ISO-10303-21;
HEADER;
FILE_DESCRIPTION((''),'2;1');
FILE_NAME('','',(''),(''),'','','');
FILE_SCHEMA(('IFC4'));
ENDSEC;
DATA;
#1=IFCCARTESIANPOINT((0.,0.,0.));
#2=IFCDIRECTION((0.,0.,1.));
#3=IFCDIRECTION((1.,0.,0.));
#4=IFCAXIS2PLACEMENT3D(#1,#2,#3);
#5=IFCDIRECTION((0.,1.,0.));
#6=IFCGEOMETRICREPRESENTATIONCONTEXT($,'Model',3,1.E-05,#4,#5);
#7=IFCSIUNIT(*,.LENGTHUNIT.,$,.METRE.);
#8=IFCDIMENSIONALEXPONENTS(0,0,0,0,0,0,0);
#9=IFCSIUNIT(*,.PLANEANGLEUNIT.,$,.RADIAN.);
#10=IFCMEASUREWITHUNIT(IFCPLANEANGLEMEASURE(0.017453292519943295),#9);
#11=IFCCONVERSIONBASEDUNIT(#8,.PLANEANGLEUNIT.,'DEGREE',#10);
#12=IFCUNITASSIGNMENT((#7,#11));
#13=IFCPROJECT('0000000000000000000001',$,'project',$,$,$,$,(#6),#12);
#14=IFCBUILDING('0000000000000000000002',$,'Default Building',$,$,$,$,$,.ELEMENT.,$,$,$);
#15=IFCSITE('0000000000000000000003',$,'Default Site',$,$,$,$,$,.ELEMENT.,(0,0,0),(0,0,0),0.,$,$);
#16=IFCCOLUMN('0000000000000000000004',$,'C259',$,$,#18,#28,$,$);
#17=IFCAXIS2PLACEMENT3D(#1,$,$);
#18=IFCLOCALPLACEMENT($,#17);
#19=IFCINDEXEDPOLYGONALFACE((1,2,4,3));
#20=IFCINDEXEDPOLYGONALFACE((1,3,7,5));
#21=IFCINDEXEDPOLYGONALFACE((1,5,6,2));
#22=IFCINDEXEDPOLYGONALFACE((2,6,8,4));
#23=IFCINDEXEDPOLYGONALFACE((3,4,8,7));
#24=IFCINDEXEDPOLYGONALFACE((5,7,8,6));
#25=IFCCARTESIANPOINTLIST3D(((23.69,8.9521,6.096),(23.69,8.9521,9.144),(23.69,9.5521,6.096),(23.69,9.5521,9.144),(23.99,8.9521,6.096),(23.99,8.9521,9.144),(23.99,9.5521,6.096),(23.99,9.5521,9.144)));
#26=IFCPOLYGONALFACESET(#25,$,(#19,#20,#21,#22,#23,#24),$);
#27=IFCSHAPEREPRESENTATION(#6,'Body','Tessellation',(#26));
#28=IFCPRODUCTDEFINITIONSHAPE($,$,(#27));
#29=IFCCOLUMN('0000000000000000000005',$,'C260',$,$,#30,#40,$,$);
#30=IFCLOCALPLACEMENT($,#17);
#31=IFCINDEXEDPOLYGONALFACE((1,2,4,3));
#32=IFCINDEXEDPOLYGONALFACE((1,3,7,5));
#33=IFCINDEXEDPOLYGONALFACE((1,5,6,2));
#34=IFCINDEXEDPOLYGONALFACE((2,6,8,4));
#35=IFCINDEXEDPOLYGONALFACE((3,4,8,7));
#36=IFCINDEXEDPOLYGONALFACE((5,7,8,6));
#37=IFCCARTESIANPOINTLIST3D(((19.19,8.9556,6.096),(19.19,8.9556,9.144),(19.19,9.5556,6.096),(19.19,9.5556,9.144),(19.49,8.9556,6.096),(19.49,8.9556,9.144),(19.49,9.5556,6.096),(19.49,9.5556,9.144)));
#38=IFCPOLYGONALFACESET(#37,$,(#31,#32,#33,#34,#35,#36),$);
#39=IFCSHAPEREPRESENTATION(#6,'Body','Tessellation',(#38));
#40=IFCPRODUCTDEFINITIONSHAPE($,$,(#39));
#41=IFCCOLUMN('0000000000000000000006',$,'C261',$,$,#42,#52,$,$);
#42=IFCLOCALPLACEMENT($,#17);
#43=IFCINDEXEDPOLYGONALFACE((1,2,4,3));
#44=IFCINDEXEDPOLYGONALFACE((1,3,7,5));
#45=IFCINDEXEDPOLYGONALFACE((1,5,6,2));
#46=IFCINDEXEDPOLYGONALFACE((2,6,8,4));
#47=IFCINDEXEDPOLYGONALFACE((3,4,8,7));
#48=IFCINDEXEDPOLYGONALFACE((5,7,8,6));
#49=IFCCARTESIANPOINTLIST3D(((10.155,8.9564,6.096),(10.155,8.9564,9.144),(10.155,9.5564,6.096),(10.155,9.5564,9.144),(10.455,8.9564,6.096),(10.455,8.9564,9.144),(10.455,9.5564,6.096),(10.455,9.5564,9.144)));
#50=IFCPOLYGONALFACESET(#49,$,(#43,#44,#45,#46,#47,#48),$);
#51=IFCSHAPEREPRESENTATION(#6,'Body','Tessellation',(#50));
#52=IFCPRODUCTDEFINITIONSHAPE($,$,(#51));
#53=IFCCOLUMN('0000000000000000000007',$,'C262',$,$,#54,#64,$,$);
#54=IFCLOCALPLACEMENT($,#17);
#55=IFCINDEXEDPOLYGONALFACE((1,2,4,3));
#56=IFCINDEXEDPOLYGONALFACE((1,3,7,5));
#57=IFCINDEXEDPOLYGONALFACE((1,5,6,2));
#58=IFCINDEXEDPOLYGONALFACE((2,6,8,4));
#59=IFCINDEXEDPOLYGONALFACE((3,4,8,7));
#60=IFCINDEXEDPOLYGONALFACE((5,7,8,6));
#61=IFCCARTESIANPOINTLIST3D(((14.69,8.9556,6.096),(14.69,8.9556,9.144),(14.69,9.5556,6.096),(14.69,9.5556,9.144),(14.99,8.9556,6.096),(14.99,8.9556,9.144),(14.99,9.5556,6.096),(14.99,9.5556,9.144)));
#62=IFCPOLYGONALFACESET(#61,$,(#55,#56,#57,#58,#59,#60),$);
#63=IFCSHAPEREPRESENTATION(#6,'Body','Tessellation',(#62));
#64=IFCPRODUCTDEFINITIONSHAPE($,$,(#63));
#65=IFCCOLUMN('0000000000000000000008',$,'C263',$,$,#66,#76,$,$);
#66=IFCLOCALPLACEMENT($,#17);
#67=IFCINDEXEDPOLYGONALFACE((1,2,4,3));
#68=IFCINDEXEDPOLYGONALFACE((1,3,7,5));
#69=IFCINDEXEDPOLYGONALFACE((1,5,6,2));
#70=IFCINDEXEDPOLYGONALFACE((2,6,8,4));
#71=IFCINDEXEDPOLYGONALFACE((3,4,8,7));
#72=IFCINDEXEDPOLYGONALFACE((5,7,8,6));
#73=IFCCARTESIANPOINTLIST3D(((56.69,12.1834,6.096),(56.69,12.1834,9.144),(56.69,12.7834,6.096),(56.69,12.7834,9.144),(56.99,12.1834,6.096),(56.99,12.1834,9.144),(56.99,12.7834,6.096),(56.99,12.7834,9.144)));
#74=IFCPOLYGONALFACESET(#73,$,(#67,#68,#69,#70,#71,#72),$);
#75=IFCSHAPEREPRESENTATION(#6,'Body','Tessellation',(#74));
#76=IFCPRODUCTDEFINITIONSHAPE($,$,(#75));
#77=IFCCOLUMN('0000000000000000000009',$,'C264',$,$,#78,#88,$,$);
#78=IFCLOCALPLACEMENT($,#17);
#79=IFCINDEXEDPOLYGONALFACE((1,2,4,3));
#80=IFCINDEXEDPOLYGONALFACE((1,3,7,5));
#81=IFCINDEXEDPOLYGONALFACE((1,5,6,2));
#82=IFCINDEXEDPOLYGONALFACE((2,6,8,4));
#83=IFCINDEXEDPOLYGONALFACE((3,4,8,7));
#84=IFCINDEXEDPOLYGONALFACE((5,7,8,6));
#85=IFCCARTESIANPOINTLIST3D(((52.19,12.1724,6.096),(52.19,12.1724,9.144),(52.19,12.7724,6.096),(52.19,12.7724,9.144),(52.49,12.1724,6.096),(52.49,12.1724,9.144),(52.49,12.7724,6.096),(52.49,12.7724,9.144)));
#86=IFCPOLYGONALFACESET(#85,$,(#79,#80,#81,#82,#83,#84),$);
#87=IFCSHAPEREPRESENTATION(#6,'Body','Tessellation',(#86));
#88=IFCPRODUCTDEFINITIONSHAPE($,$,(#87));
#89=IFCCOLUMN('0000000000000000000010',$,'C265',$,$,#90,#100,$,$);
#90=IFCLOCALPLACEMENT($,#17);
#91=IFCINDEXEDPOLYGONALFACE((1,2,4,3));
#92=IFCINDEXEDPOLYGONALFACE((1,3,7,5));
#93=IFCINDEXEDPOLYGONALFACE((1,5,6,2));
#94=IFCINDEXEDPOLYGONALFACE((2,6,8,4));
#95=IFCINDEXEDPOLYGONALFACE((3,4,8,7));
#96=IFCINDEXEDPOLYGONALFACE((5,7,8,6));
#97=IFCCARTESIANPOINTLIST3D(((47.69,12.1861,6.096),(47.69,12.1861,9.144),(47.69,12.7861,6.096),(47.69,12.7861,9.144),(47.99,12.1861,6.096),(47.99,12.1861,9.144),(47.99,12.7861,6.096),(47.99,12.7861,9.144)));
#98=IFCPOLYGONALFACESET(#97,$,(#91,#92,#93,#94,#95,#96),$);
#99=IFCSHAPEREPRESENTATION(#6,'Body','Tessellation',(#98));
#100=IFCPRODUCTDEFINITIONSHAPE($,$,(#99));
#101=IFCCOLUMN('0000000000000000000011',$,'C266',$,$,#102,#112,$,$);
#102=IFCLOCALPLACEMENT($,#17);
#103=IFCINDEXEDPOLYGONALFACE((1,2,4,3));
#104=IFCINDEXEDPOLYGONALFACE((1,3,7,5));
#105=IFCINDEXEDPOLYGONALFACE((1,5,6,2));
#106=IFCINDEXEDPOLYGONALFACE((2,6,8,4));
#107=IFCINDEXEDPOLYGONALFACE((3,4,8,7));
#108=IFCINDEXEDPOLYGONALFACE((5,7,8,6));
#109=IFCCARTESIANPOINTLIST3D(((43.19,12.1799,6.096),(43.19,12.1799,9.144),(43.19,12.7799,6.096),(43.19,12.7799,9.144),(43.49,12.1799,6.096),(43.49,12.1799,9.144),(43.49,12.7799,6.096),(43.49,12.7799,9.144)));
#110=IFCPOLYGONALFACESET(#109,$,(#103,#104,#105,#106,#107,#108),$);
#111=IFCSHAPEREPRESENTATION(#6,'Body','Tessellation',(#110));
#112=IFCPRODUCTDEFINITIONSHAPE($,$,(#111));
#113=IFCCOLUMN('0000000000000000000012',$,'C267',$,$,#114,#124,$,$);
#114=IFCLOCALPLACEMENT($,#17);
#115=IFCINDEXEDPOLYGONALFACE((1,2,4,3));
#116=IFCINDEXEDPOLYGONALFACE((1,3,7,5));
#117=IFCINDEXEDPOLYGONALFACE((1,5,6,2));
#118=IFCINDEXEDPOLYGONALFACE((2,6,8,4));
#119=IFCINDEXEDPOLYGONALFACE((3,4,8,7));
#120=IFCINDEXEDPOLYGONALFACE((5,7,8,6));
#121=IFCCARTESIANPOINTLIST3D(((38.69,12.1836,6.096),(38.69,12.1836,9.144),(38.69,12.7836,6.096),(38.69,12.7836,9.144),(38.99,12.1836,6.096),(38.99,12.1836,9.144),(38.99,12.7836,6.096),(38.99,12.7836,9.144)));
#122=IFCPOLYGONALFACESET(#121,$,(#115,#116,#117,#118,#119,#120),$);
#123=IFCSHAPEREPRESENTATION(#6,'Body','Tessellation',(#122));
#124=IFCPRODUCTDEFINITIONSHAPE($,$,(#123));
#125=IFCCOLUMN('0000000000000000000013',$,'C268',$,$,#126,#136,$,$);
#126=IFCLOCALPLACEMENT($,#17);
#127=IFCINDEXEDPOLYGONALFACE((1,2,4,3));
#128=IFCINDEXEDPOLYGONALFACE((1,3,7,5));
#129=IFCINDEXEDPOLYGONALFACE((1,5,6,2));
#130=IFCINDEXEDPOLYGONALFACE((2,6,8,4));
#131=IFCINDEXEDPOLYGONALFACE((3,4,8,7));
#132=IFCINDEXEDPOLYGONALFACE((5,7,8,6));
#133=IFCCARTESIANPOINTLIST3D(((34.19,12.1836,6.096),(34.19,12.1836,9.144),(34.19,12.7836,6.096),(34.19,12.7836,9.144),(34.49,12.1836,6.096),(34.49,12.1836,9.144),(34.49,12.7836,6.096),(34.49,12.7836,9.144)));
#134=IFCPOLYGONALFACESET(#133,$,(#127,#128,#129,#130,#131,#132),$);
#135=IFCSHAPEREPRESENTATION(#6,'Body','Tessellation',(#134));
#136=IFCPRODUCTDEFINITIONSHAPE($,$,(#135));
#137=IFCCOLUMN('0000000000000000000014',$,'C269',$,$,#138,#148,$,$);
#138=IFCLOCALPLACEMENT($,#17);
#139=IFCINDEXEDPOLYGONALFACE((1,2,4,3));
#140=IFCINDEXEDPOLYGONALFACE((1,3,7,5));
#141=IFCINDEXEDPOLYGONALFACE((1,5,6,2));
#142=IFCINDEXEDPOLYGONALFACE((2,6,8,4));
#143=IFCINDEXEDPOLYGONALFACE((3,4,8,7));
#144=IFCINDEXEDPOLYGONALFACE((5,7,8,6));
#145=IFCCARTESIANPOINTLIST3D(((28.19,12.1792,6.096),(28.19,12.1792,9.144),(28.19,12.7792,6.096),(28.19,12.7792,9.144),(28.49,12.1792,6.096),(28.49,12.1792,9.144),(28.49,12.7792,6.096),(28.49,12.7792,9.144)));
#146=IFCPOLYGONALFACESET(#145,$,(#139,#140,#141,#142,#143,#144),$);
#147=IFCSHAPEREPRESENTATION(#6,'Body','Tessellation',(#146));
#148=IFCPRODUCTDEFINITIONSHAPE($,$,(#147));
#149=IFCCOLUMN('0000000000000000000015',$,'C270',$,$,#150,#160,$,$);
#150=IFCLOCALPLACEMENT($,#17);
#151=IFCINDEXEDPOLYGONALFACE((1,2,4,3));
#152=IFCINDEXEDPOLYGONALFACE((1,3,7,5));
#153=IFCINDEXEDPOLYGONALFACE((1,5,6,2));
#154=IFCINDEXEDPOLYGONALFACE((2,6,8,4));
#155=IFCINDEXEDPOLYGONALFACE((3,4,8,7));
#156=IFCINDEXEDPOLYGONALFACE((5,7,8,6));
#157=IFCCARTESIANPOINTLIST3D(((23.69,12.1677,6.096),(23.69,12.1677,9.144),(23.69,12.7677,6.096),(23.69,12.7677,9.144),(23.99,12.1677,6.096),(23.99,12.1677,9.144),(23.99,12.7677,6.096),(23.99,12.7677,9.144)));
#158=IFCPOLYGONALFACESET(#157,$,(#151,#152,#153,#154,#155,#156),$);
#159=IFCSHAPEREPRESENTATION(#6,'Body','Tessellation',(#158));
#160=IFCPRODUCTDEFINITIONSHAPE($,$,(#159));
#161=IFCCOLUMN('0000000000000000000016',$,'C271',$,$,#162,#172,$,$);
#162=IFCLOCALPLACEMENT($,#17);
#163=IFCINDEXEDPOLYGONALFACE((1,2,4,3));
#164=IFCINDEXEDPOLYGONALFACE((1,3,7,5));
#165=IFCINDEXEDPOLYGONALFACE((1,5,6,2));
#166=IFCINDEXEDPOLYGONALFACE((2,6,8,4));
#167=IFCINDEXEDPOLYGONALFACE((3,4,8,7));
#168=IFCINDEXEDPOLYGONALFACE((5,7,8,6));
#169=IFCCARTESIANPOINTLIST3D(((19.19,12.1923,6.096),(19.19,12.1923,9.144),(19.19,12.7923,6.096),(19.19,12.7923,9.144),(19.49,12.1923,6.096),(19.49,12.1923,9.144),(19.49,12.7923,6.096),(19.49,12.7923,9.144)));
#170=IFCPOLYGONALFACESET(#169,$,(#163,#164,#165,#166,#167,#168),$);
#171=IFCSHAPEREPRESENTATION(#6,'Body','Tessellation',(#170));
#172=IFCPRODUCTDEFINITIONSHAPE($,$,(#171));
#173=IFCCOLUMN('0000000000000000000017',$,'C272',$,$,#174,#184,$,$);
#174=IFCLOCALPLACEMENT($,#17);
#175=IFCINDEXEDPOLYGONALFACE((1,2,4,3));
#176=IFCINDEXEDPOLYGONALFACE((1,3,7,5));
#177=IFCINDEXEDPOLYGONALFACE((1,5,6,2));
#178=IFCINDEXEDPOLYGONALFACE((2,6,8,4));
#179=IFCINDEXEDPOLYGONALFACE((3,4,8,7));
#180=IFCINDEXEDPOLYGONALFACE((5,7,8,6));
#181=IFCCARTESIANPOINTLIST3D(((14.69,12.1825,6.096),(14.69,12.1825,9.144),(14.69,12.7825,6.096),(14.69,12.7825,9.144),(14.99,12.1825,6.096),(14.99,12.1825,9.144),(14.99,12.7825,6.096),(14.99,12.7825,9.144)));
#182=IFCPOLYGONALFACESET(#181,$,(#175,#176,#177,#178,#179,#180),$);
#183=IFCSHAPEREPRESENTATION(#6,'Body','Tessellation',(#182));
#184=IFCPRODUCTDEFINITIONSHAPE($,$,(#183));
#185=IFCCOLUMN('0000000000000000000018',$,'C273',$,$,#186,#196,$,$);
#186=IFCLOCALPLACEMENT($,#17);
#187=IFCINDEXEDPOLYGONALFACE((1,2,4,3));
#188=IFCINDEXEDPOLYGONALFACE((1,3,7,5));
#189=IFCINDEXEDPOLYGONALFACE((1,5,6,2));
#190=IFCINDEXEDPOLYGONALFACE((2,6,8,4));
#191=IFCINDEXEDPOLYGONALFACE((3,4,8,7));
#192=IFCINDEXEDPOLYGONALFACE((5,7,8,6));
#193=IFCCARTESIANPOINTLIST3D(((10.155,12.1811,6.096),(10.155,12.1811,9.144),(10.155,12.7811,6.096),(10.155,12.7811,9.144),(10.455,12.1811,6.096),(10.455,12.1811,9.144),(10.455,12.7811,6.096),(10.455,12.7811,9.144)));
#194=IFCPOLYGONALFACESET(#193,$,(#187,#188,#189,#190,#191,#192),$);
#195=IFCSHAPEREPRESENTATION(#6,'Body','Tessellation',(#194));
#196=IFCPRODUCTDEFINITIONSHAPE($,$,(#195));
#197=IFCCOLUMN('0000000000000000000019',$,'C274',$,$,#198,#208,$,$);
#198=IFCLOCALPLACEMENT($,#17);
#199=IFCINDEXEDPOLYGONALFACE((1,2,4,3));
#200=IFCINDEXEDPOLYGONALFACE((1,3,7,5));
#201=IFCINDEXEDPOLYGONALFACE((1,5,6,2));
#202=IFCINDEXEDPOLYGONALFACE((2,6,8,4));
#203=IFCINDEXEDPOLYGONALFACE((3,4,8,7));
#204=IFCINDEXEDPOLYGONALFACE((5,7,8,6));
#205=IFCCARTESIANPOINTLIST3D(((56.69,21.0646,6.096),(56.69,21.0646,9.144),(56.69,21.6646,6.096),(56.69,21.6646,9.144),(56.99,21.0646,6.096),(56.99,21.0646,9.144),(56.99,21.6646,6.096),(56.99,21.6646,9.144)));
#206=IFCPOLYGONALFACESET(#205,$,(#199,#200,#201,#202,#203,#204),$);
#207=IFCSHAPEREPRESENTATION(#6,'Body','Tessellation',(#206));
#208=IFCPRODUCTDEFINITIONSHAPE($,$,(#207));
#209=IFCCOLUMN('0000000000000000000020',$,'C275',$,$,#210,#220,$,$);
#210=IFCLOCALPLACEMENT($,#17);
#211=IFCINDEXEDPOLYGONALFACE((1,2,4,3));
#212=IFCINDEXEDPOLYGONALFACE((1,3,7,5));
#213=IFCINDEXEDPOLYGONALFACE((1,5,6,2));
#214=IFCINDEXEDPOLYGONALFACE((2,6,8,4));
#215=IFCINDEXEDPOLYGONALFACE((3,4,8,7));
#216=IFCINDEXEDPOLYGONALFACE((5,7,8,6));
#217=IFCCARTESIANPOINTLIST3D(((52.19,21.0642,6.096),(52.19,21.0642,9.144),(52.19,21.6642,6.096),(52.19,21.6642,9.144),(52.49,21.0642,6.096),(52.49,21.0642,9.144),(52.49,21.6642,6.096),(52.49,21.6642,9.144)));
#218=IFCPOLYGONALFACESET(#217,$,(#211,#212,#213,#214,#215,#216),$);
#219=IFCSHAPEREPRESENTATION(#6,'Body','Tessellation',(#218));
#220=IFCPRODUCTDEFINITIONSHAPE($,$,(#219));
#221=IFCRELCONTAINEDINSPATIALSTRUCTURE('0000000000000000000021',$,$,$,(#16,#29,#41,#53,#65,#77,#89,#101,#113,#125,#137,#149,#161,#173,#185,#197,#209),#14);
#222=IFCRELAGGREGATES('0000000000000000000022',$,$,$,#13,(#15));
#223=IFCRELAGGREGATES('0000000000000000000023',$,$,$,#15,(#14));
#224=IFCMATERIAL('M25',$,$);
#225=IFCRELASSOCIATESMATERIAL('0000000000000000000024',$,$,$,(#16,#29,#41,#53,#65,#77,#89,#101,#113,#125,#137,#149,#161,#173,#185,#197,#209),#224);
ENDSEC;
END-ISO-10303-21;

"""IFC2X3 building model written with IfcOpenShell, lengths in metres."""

from ifc_helpers import new_model, entity, si_unit, converted_unit, direction, frame, frame_2d, origin_with_axes, place, context, project, spatial, rectangle, extrude, material, element, save


model = new_model("IFC2X3")

# Units and contexts
model_context = context("Model", 3, precision=1e-05, world=origin_with_axes(), true_north=direction((0.0, 1.0, 0.0)))
ifc_project = project(units=[si_unit("LENGTHUNIT", "METRE"), converted_unit("PLANEANGLEUNIT", "DEGREE", entity("IfcPlaneAngleMeasure", 0.017453292519943295), si_unit("PLANEANGLEUNIT", "RADIAN"), dimensions=[0, 0, 0, 0, 0, 0, 0])], contexts=[model_context])

# Site, building
site = spatial("IfcSite", under=ifc_project, Name="Default Site", CompositionType="ELEMENT", RefLatitude=(0, 0, 0), RefLongitude=(0, 0, 0), RefElevation=0.0)
building = spatial("IfcBuilding", under=site, Name="Default Building", CompositionType="ELEMENT")

# Columns
ifc_material = material(Name="M25")
placement = place(None, origin_with_axes())
element("IfcColumn", 1, at=placement, inside=building, material=ifc_material, Name="C259", context=model_context, shape_type="SweptSolid", body=[
    extrude(rectangle(XDim=0.3, YDim=0.6, at=frame_2d((0.0, 0.0), x_axis=(1.0, 0.0, 0.0))), frame((23.84, 9.2521, 6.096), z_axis=(0.0, 0.0, 1.0), x_axis=(1.0, 0.0, 0.0)), (0.0, 0.0, 1.0), 3.048),
])
element("IfcColumn", 2, at=placement, inside=building, material=ifc_material, Name="C260", context=model_context, shape_type="SweptSolid", body=[
    extrude(rectangle(XDim=0.3, YDim=0.6, at=frame_2d((0.0, 0.0), x_axis=(1.0, 0.0, 0.0))), frame((19.34, 9.2556, 6.096), z_axis=(0.0, 0.0, 1.0), x_axis=(1.0, 0.0, 0.0)), (0.0, 0.0, 1.0), 3.048),
])
element("IfcColumn", 3, at=placement, inside=building, material=ifc_material, Name="C261", context=model_context, shape_type="SweptSolid", body=[
    extrude(rectangle(XDim=0.3, YDim=0.6, at=frame_2d((0.0, 0.0), x_axis=(1.0, 0.0, 0.0))), frame((10.305, 9.2564, 6.096), z_axis=(0.0, 0.0, 1.0), x_axis=(1.0, 0.0, 0.0)), (0.0, 0.0, 1.0), 3.048),
])
element("IfcColumn", 4, at=placement, inside=building, material=ifc_material, Name="C262", context=model_context, shape_type="SweptSolid", body=[
    extrude(rectangle(XDim=0.3, YDim=0.6, at=frame_2d((0.0, 0.0), x_axis=(1.0, 0.0, 0.0))), frame((14.84, 9.2556, 6.096), z_axis=(0.0, 0.0, 1.0), x_axis=(1.0, 0.0, 0.0)), (0.0, 0.0, 1.0), 3.048),
])
element("IfcColumn", 5, at=placement, inside=building, material=ifc_material, Name="C263", context=model_context, shape_type="SweptSolid", body=[
    extrude(rectangle(XDim=0.3, YDim=0.6, at=frame_2d((0.0, 0.0), x_axis=(1.0, 0.0, 0.0))), frame((56.84, 12.4834, 6.096), z_axis=(0.0, 0.0, 1.0), x_axis=(1.0, 0.0, 0.0)), (0.0, 0.0, 1.0), 3.048),
])
element("IfcColumn", 6, at=placement, inside=building, material=ifc_material, Name="C264", context=model_context, shape_type="SweptSolid", body=[
    extrude(rectangle(XDim=0.3, YDim=0.6, at=frame_2d((0.0, 0.0), x_axis=(1.0, 0.0, 0.0))), frame((52.34, 12.4724, 6.096), z_axis=(0.0, 0.0, 1.0), x_axis=(1.0, 0.0, 0.0)), (0.0, 0.0, 1.0), 3.048),
])
element("IfcColumn", 7, at=placement, inside=building, material=ifc_material, Name="C265", context=model_context, shape_type="SweptSolid", body=[
    extrude(rectangle(XDim=0.3, YDim=0.6, at=frame_2d((0.0, 0.0), x_axis=(1.0, 0.0, 0.0))), frame((47.84, 12.4861, 6.096), z_axis=(0.0, 0.0, 1.0), x_axis=(1.0, 0.0, 0.0)), (0.0, 0.0, 1.0), 3.048),
])
element("IfcColumn", 8, at=placement, inside=building, material=ifc_material, Name="C266", context=model_context, shape_type="SweptSolid", body=[
    extrude(rectangle(XDim=0.3, YDim=0.6, at=frame_2d((0.0, 0.0), x_axis=(1.0, 0.0, 0.0))), frame((43.34, 12.4799, 6.096), z_axis=(0.0, 0.0, 1.0), x_axis=(1.0, 0.0, 0.0)), (0.0, 0.0, 1.0), 3.048),
])
element("IfcColumn", 9, at=placement, inside=building, material=ifc_material, Name="C267", context=model_context, shape_type="SweptSolid", body=[
    extrude(rectangle(XDim=0.3, YDim=0.6, at=frame_2d((0.0, 0.0), x_axis=(1.0, 0.0, 0.0))), frame((38.84, 12.4836, 6.096), z_axis=(0.0, 0.0, 1.0), x_axis=(1.0, 0.0, 0.0)), (0.0, 0.0, 1.0), 3.048),
])
element("IfcColumn", 10, at=placement, inside=building, material=ifc_material, Name="C268", context=model_context, shape_type="SweptSolid", body=[
    extrude(rectangle(XDim=0.3, YDim=0.6, at=frame_2d((0.0, 0.0), x_axis=(1.0, 0.0, 0.0))), frame((34.34, 12.4836, 6.096), z_axis=(0.0, 0.0, 1.0), x_axis=(1.0, 0.0, 0.0)), (0.0, 0.0, 1.0), 3.048),
])
element("IfcColumn", 11, at=placement, inside=building, material=ifc_material, Name="C269", context=model_context, shape_type="SweptSolid", body=[
    extrude(rectangle(XDim=0.3, YDim=0.6, at=frame_2d((0.0, 0.0), x_axis=(1.0, 0.0, 0.0))), frame((28.34, 12.4792, 6.096), z_axis=(0.0, 0.0, 1.0), x_axis=(1.0, 0.0, 0.0)), (0.0, 0.0, 1.0), 3.048),
])
element("IfcColumn", 12, at=placement, inside=building, material=ifc_material, Name="C270", context=model_context, shape_type="SweptSolid", body=[
    extrude(rectangle(XDim=0.3, YDim=0.6, at=frame_2d((0.0, 0.0), x_axis=(1.0, 0.0, 0.0))), frame((23.84, 12.4677, 6.096), z_axis=(0.0, 0.0, 1.0), x_axis=(1.0, 0.0, 0.0)), (0.0, 0.0, 1.0), 3.048),
])
element("IfcColumn", 13, at=placement, inside=building, material=ifc_material, Name="C271", context=model_context, shape_type="SweptSolid", body=[
    extrude(rectangle(XDim=0.3, YDim=0.6, at=frame_2d((0.0, 0.0), x_axis=(1.0, 0.0, 0.0))), frame((19.34, 12.4923, 6.096), z_axis=(0.0, 0.0, 1.0), x_axis=(1.0, 0.0, 0.0)), (0.0, 0.0, 1.0), 3.048),
])
element("IfcColumn", 14, at=placement, inside=building, material=ifc_material, Name="C272", context=model_context, shape_type="SweptSolid", body=[
    extrude(rectangle(XDim=0.3, YDim=0.6, at=frame_2d((0.0, 0.0), x_axis=(1.0, 0.0, 0.0))), frame((14.84, 12.4825, 6.096), z_axis=(0.0, 0.0, 1.0), x_axis=(1.0, 0.0, 0.0)), (0.0, 0.0, 1.0), 3.048),
])
element("IfcColumn", 15, at=placement, inside=building, material=ifc_material, Name="C273", context=model_context, shape_type="SweptSolid", body=[
    extrude(rectangle(XDim=0.3, YDim=0.6, at=frame_2d((0.0, 0.0), x_axis=(1.0, 0.0, 0.0))), frame((10.305, 12.4811, 6.096), z_axis=(0.0, 0.0, 1.0), x_axis=(1.0, 0.0, 0.0)), (0.0, 0.0, 1.0), 3.048),
])
element("IfcColumn", 16, at=placement, inside=building, material=ifc_material, Name="C274", context=model_context, shape_type="SweptSolid", body=[
    extrude(rectangle(XDim=0.3, YDim=0.6, at=frame_2d((0.0, 0.0), x_axis=(1.0, 0.0, 0.0))), frame((56.84, 21.3646, 6.096), z_axis=(0.0, 0.0, 1.0), x_axis=(1.0, 0.0, 0.0)), (0.0, 0.0, 1.0), 3.048),
])
element("IfcColumn", 17, at=placement, inside=building, material=ifc_material, Name="C275", context=model_context, shape_type="SweptSolid", body=[
    extrude(rectangle(XDim=0.3, YDim=0.6, at=frame_2d((0.0, 0.0), x_axis=(1.0, 0.0, 0.0))), frame((52.34, 21.3642, 6.096), z_axis=(0.0, 0.0, 1.0), x_axis=(1.0, 0.0, 0.0)), (0.0, 0.0, 1.0), 3.048),
])

save(model, "model.ifc")
